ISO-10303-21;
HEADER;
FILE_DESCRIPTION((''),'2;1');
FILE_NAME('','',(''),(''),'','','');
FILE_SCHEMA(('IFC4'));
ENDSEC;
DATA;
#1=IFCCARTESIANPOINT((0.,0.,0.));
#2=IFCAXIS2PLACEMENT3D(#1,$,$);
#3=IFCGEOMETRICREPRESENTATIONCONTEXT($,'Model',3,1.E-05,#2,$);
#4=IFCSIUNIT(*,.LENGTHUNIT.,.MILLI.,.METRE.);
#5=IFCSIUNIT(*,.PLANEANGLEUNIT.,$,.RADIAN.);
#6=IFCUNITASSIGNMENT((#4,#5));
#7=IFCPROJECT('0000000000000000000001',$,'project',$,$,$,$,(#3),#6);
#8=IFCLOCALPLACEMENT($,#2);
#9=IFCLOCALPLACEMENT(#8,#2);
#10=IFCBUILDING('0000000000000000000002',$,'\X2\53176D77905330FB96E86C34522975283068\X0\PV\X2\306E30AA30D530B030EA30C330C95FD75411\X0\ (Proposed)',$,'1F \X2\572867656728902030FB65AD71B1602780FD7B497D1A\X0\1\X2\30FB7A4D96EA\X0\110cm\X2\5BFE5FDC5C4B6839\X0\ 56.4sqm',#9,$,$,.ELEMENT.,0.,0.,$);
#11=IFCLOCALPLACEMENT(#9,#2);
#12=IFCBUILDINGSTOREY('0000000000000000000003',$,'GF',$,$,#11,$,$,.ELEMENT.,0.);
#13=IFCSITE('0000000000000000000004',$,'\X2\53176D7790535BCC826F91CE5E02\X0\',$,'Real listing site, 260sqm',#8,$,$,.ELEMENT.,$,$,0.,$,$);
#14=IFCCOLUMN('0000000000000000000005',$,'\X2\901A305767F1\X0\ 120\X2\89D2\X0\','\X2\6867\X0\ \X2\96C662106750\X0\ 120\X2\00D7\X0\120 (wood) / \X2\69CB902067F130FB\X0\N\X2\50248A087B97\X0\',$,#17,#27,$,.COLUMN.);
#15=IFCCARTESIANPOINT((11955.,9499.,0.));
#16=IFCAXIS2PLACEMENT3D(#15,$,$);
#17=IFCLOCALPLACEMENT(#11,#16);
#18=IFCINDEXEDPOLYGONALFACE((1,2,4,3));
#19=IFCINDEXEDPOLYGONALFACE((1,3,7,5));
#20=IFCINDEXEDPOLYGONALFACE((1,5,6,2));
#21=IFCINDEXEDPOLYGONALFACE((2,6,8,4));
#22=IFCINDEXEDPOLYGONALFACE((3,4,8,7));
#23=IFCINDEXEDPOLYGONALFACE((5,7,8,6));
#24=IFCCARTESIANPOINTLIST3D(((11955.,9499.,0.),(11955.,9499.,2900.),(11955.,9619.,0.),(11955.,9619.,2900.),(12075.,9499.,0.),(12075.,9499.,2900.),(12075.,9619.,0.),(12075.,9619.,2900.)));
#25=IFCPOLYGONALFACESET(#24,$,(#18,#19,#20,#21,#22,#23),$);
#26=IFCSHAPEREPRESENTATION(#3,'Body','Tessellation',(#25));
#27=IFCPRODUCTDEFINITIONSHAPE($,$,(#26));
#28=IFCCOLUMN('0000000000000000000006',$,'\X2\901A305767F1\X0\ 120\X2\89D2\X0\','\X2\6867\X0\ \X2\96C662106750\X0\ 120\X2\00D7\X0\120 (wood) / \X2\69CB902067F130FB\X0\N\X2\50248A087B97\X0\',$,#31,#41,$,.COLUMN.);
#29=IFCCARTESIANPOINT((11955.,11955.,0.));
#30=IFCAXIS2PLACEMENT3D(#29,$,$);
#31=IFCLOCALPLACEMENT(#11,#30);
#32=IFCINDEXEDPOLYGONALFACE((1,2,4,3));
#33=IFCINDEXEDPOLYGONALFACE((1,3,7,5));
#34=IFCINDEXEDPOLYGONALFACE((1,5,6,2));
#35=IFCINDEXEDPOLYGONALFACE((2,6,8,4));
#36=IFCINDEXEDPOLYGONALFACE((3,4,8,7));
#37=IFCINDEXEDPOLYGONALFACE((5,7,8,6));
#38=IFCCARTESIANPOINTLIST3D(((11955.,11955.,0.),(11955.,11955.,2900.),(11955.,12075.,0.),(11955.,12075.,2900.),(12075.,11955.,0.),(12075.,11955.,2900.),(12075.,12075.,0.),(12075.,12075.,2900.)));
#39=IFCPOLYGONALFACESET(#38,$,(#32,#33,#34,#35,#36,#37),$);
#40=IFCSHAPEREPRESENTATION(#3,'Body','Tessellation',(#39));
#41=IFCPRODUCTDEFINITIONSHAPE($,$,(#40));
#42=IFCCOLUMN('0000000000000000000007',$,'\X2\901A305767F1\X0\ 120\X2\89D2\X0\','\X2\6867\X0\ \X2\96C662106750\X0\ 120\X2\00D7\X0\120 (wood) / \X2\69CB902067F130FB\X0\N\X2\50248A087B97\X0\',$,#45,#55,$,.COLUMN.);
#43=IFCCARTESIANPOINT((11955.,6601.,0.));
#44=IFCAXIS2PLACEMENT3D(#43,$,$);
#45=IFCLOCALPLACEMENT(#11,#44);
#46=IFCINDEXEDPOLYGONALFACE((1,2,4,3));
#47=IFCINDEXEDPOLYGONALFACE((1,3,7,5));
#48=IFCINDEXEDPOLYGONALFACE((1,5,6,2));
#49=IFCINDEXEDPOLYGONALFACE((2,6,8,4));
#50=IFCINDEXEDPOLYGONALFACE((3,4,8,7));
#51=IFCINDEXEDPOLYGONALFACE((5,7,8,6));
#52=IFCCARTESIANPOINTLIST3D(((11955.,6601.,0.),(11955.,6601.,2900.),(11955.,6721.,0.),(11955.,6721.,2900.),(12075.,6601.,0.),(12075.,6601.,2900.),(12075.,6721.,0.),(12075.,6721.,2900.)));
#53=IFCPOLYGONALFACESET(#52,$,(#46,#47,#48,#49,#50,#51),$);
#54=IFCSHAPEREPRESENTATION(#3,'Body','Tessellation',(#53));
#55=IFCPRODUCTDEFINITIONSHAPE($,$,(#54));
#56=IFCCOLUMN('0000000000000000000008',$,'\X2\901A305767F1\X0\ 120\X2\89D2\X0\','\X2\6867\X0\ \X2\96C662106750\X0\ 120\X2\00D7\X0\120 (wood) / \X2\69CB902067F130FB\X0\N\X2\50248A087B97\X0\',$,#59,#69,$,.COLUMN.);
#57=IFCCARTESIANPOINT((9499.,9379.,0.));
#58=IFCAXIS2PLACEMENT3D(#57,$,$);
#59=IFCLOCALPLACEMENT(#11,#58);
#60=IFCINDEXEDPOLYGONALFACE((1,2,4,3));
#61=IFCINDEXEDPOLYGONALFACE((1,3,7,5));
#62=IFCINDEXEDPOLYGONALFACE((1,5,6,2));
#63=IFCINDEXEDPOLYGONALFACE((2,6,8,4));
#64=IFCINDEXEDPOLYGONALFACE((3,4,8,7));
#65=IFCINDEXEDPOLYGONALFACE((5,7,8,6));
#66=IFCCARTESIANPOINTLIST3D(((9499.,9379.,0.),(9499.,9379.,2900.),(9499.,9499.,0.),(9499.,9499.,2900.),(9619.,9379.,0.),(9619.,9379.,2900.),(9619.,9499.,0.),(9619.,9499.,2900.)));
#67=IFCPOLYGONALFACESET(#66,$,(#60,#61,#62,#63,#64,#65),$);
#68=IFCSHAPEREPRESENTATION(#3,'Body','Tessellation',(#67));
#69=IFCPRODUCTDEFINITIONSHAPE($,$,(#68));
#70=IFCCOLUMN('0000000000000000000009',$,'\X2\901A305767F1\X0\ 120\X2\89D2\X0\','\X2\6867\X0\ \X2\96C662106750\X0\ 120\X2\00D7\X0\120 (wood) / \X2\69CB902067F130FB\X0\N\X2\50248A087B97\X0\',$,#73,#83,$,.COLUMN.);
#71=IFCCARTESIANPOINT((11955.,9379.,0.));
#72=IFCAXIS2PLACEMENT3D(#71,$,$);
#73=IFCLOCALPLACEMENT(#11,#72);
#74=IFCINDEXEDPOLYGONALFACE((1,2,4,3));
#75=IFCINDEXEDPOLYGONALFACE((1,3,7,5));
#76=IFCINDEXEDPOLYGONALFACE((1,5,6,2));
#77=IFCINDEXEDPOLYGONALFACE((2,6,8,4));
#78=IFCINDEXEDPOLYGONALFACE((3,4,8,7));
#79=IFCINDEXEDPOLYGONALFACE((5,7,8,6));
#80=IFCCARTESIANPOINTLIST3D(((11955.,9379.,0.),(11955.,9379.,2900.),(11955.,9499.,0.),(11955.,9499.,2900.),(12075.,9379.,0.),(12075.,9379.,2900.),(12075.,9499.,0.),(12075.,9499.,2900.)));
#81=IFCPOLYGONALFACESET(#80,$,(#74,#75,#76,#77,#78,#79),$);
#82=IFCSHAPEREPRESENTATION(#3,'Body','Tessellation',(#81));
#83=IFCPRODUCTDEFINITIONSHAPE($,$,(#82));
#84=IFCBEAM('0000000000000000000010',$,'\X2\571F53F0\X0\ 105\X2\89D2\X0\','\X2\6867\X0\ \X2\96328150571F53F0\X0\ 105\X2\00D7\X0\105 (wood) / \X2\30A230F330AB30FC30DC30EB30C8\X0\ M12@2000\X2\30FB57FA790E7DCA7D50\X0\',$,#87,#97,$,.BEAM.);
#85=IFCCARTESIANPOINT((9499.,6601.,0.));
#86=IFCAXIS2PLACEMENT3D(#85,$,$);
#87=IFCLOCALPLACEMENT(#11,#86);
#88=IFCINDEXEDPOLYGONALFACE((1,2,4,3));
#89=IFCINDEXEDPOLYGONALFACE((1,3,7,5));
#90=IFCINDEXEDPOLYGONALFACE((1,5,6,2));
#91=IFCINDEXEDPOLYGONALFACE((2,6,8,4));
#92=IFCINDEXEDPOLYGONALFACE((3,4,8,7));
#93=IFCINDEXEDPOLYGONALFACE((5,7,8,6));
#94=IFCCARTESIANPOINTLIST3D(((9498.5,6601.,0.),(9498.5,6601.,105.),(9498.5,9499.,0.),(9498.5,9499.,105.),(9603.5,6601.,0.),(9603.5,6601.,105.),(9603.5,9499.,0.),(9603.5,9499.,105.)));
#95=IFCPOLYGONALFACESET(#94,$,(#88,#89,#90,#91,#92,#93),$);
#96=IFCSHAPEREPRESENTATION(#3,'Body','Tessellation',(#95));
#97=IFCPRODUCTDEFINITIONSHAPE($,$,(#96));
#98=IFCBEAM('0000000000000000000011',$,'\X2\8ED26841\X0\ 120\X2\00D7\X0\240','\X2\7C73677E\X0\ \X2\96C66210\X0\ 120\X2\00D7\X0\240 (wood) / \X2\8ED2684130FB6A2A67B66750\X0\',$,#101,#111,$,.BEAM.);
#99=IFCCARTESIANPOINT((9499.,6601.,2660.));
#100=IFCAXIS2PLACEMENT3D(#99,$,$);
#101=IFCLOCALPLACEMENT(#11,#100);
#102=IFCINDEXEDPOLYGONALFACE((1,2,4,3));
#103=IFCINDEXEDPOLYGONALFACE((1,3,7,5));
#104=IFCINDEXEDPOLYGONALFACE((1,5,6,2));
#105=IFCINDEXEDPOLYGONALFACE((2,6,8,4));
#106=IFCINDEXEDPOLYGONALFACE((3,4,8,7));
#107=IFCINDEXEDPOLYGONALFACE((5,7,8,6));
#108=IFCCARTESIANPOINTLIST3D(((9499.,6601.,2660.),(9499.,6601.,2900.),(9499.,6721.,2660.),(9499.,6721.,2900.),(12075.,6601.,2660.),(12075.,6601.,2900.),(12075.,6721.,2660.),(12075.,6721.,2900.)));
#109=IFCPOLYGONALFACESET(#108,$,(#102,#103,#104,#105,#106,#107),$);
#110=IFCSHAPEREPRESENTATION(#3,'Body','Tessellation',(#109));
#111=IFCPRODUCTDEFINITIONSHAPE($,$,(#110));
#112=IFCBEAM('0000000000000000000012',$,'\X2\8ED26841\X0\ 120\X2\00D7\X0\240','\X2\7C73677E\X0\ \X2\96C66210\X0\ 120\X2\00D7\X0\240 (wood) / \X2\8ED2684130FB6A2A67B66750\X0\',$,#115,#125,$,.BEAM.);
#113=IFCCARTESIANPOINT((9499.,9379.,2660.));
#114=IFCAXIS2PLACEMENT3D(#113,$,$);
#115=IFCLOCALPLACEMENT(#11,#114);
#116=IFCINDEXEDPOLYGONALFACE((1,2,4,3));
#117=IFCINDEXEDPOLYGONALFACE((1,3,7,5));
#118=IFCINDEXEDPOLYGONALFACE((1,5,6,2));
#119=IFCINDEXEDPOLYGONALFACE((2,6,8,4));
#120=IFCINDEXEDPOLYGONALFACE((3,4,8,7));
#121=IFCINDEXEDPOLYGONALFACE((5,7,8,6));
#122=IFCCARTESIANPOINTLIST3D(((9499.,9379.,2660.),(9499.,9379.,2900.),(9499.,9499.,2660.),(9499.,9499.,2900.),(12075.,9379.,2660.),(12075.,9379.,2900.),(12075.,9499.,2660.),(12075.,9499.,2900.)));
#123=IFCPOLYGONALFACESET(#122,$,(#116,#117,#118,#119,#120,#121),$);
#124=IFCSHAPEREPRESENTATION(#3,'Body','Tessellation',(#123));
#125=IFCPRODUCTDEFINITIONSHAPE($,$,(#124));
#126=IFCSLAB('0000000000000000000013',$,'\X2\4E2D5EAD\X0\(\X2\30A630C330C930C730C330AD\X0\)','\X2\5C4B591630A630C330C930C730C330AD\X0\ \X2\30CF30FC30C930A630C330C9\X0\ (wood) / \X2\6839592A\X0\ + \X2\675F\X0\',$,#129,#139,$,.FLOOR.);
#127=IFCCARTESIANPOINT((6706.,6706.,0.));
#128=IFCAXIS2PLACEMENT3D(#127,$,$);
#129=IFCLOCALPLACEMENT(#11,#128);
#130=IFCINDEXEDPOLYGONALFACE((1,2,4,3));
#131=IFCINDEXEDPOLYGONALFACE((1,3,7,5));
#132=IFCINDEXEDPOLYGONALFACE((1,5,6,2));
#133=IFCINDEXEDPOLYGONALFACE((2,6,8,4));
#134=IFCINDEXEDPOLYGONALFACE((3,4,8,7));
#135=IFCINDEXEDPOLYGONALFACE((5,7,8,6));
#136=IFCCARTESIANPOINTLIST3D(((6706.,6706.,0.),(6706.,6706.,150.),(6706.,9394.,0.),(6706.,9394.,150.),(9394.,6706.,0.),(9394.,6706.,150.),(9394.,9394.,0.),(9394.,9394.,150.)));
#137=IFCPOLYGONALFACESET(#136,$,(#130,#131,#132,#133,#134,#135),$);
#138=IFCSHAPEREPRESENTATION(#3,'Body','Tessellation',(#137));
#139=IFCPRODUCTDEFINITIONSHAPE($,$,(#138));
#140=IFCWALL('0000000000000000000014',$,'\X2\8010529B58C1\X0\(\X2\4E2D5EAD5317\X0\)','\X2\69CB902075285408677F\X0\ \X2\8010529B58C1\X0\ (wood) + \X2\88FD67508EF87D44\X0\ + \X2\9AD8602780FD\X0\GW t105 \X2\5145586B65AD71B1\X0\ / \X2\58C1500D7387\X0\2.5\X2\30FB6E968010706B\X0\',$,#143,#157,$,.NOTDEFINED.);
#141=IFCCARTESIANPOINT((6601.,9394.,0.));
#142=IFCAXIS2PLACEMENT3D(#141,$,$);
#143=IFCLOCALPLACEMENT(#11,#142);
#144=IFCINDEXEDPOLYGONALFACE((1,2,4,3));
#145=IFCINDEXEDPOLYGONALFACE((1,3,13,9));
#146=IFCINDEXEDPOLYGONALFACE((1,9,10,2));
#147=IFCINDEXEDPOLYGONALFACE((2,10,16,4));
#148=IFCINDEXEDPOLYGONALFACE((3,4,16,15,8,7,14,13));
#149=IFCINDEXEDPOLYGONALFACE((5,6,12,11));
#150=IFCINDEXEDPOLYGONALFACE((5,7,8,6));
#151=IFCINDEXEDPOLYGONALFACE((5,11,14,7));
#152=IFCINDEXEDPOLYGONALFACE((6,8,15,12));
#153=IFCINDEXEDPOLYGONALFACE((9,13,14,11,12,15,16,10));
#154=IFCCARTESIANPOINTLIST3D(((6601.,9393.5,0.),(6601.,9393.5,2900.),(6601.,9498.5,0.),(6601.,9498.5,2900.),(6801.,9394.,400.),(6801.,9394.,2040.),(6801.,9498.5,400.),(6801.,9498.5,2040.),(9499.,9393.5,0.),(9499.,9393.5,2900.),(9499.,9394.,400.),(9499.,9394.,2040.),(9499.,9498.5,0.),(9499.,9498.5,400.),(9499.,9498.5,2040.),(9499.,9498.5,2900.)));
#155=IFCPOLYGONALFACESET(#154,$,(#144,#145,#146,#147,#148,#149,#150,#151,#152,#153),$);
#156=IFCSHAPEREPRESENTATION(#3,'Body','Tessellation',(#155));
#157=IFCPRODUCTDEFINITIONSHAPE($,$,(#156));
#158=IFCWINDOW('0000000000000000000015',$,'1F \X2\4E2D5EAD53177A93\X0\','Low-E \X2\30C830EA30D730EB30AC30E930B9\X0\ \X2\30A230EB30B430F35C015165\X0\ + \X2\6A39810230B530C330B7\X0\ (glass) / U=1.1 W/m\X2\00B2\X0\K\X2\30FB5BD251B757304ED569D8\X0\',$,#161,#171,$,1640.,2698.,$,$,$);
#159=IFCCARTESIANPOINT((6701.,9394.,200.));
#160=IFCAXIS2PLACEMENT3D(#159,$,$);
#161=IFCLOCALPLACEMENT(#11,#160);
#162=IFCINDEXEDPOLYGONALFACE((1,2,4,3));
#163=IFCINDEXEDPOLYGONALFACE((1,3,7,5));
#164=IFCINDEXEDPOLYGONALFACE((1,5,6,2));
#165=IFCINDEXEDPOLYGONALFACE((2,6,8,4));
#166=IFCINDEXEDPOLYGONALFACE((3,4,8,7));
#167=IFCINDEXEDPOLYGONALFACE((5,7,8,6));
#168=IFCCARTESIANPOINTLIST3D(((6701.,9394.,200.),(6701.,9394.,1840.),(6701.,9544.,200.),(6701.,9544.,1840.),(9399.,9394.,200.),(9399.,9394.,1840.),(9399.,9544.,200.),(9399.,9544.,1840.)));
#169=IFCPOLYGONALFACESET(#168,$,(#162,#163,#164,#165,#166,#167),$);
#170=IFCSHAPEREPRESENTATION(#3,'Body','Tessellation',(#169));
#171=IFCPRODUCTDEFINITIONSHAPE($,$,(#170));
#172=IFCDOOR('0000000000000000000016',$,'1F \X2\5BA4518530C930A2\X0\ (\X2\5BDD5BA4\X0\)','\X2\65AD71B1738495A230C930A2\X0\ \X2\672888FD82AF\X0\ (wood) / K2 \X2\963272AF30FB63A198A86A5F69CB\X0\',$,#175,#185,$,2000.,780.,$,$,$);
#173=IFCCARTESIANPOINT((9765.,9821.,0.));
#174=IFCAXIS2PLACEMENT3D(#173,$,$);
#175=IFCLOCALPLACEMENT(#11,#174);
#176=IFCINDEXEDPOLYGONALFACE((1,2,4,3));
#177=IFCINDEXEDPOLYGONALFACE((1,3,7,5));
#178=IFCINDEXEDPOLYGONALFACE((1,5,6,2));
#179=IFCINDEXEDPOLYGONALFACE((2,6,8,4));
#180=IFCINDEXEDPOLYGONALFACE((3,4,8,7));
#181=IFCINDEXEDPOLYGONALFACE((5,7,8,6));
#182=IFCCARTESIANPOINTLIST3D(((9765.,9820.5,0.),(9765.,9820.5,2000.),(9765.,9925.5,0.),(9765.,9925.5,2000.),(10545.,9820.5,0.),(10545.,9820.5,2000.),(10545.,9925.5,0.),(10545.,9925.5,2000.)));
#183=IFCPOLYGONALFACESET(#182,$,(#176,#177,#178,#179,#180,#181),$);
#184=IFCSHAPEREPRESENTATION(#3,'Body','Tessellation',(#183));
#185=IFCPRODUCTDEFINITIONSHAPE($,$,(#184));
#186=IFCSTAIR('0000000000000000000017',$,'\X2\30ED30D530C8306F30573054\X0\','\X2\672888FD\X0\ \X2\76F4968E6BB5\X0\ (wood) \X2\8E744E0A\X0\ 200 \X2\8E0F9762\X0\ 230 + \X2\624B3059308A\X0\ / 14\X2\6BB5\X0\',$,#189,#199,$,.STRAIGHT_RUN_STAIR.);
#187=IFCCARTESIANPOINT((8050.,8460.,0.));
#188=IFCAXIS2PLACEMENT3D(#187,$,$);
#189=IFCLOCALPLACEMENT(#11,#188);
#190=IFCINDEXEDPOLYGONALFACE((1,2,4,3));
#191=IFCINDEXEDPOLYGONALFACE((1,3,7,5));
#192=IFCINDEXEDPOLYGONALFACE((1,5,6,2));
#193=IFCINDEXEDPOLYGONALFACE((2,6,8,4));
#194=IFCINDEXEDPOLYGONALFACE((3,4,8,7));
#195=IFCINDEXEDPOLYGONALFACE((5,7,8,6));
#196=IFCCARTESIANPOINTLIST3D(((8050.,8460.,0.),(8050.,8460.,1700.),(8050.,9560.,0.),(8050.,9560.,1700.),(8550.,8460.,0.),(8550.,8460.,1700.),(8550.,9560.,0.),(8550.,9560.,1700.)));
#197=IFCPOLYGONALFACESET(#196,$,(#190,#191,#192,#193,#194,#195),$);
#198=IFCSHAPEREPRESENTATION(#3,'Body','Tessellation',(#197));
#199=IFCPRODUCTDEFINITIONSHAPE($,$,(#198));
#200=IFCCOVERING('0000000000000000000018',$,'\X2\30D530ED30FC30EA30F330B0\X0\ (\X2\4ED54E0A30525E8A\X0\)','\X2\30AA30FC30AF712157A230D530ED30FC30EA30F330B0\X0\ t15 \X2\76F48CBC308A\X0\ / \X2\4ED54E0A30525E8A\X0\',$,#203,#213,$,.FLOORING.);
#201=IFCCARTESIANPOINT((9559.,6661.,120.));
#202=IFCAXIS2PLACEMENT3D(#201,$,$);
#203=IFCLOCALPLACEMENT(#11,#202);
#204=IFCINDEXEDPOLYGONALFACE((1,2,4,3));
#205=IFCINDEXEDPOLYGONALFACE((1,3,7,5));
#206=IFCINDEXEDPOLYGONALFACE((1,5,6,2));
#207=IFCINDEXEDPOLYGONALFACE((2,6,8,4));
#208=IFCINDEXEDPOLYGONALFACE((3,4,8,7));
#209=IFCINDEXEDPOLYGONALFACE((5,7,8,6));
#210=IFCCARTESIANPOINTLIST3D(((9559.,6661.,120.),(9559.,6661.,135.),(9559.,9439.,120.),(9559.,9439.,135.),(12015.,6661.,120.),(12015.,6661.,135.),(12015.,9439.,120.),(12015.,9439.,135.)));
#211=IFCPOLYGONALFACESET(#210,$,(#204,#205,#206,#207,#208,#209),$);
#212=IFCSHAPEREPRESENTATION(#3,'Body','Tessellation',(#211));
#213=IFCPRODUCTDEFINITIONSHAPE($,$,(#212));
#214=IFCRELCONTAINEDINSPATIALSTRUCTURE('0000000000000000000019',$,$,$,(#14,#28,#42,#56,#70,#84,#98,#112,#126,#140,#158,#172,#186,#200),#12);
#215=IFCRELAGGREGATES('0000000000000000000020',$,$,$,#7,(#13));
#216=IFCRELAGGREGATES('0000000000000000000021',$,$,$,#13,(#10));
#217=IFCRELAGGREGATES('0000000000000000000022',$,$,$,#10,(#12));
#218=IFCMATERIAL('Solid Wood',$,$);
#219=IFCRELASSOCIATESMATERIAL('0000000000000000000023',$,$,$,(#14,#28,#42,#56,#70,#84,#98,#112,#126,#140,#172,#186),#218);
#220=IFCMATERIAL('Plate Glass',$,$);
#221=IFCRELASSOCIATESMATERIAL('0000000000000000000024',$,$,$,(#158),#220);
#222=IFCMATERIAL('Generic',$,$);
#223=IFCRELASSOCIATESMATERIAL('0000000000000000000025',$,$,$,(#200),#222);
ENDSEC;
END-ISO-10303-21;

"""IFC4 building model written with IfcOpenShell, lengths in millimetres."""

from ifc_helpers import new_model, si_unit, frame, frame_2d, origin, place, context, project, spatial, rectangle, extrude, material, element, fill, save


model = new_model("IFC4")

# Units and contexts
model_context = context("Model", 3, precision=1e-05, world=origin())
ifc_project = project(units=[si_unit("LENGTHUNIT", "METRE", prefix="MILLI"), si_unit("PLANEANGLEUNIT", "RADIAN")], contexts=[model_context])

# Site, building, storey
site_placement = place(None, origin())
site = spatial("IfcSite", under=ifc_project, at=site_placement, Name="北海道富良野市", ObjectType="Real listing site, 260sqm", CompositionType="ELEMENT", RefElevation=0.0)
building_placement = place(site_placement, origin())
building = spatial("IfcBuilding", under=site, at=building_placement, Name="北海道・雨水利用とPVのオフグリッド志向 (Proposed)", ObjectType="1F 在来木造・断熱性能等級1・積雪110cm対応屋根 56.4sqm", CompositionType="ELEMENT", ElevationOfRefHeight=0.0, ElevationOfTerrain=0.0)
storey_placement = place(building_placement, origin())
storey = spatial("IfcBuildingStorey", under=building, at=storey_placement, Name="GF", CompositionType="ELEMENT", Elevation=0.0)

# Columns
ifc_material_1 = material(Name="Solid Wood")
column_1_placement = place(storey_placement, frame((11955.0, 9499.0, 0.0)))
element("IfcColumn", 1, at=column_1_placement, inside=storey, material=ifc_material_1, Name="通し柱 120角", Description="桧 集成材 120×120 (wood) / 構造柱・N値計算", PredefinedType="COLUMN", context=model_context, shape_type="SweptSolid", body=[
    extrude(rectangle(XDim=120.0, YDim=120.0, at=frame_2d((60.0, 60.0))), frame((11955.0, 9499.0, 0.0)), (0.0, 0.0, 1.0), 2900.0),
])
column_2_placement = place(storey_placement, frame((11955.0, 11955.0, 0.0)))
element("IfcColumn", 2, at=column_2_placement, inside=storey, material=ifc_material_1, Name="通し柱 120角", Description="桧 集成材 120×120 (wood) / 構造柱・N値計算", PredefinedType="COLUMN", context=model_context, shape_type="SweptSolid", body=[
    extrude(rectangle(XDim=120.0, YDim=120.0, at=frame_2d((60.0, 60.0))), frame((11955.0, 11955.0, 0.0)), (0.0, 0.0, 1.0), 2900.0),
])
column_3_placement = place(storey_placement, frame((11955.0, 6601.0, 0.0)))
element("IfcColumn", 3, at=column_3_placement, inside=storey, material=ifc_material_1, Name="通し柱 120角", Description="桧 集成材 120×120 (wood) / 構造柱・N値計算", PredefinedType="COLUMN", context=model_context, shape_type="SweptSolid", body=[
    extrude(rectangle(XDim=120.0, YDim=120.0, at=frame_2d((60.0, 60.0))), frame((11955.0, 6601.0, 0.0)), (0.0, 0.0, 1.0), 2900.0),
])
column_4_placement = place(storey_placement, frame((9499.0, 9379.0, 0.0)))
element("IfcColumn", 4, at=column_4_placement, inside=storey, material=ifc_material_1, Name="通し柱 120角", Description="桧 集成材 120×120 (wood) / 構造柱・N値計算", PredefinedType="COLUMN", context=model_context, shape_type="SweptSolid", body=[
    extrude(rectangle(XDim=120.0, YDim=120.0, at=frame_2d((60.0, 60.0))), frame((9499.0, 9379.0, 0.0)), (0.0, 0.0, 1.0), 2900.0),
])
column_5_placement = place(storey_placement, frame((11955.0, 9379.0, 0.0)))
element("IfcColumn", 5, at=column_5_placement, inside=storey, material=ifc_material_1, Name="通し柱 120角", Description="桧 集成材 120×120 (wood) / 構造柱・N値計算", PredefinedType="COLUMN", context=model_context, shape_type="SweptSolid", body=[
    extrude(rectangle(XDim=120.0, YDim=120.0, at=frame_2d((60.0, 60.0))), frame((11955.0, 9379.0, 0.0)), (0.0, 0.0, 1.0), 2900.0),
])

# Beams
beam_1_placement = place(storey_placement, frame((9499.0, 6601.0, 0.0)))
element("IfcBeam", 6, at=beam_1_placement, inside=storey, material=ifc_material_1, Name="土台 105角", Description="桧 防腐土台 105×105 (wood) / アンカーボルト M12@2000・基礎緊結", PredefinedType="BEAM", context=model_context, shape_type="SweptSolid", body=[
    extrude(rectangle(XDim=105.0, YDim=2898.0, at=frame_2d((52.0, 1449.0))), frame((9499.0, 6601.0, 0.0)), (0.0, 0.0, 1.0), 105.0),
])
beam_2_placement = place(storey_placement, frame((9499.0, 6601.0, 2660.0)))
element("IfcBeam", 7, at=beam_2_placement, inside=storey, material=ifc_material_1, Name="軒桁 120×240", Description="米松 集成 120×240 (wood) / 軒桁・横架材", PredefinedType="BEAM", context=model_context, shape_type="SweptSolid", body=[
    extrude(rectangle(XDim=2576.0, YDim=120.0, at=frame_2d((1288.0, 60.0))), frame((9499.0, 6601.0, 2660.0)), (0.0, 0.0, 1.0), 240.0),
])
beam_3_placement = place(storey_placement, frame((9499.0, 9379.0, 2660.0)))
element("IfcBeam", 8, at=beam_3_placement, inside=storey, material=ifc_material_1, Name="軒桁 120×240", Description="米松 集成 120×240 (wood) / 軒桁・横架材", PredefinedType="BEAM", context=model_context, shape_type="SweptSolid", body=[
    extrude(rectangle(XDim=2576.0, YDim=120.0, at=frame_2d((1288.0, 60.0))), frame((9499.0, 9379.0, 2660.0)), (0.0, 0.0, 1.0), 240.0),
])

# Slab
slab_placement = place(storey_placement, frame((6706.0, 6706.0, 0.0)))
element("IfcSlab", 9, at=slab_placement, inside=storey, material=ifc_material_1, Name="中庭(ウッドデッキ)", Description="屋外ウッドデッキ ハードウッド (wood) / 根太 + 束", PredefinedType="FLOOR", context=model_context, shape_type="SweptSolid", body=[
    extrude(rectangle(XDim=2688.0, YDim=2688.0, at=frame_2d((1344.0, 1344.0))), frame((6706.0, 6706.0, 0.0)), (0.0, 0.0, 1.0), 150.0),
])

# Wall, opening, window
wall_1_placement = place(storey_placement, frame((6601.0, 9394.0, 0.0)))
wall_1 = element("IfcWall", 10, at=wall_1_placement, inside=storey, material=ifc_material_1, Name="耐力壁(中庭北)", Description="構造用合板 耐力壁 (wood) + 製材軸組 + 高性能GW t105 充填断熱 / 壁倍率2.5・準耐火", PredefinedType="NOTDEFINED", context=model_context, shape_type="SweptSolid", body=[
    extrude(rectangle(XDim=2898.0, YDim=105.0, at=frame_2d((1449.0, 52.0))), frame((6601.0, 9394.0, 0.0)), (0.0, 0.0, 1.0), 2900.0),
])
opening_placement = place(storey_placement, frame((6701.0, 9394.0, 200.0)))
opening = element("IfcOpeningElement", 11, at=opening_placement, cuts=wall_1, PredefinedType="NOTDEFINED", context=model_context, shape_type="SweptSolid", body=[
    extrude(rectangle(XDim=2698.0, YDim=150.0, at=frame_2d((1349.0, 75.0))), frame((6701.0, 9394.0, 200.0)), (0.0, 0.0, 1.0), 1640.0),
])
ifc_material_2 = material(Name="Plate Glass")
window_placement = place(storey_placement, frame((6701.0, 9394.0, 200.0)))
window = element("IfcWindow", 12, at=window_placement, inside=storey, material=ifc_material_2, Name="1F 中庭北窓", Description="Low-E トリプルガラス アルゴン封入 + 樹脂サッシ (glass) / U=1.1 W/m²K・寒冷地仕様", OverallHeight=1640.0, OverallWidth=2698.0, context=model_context, shape_type="SweptSolid", body=[
    extrude(rectangle(XDim=2698.0, YDim=150.0, at=frame_2d((1349.0, 75.0))), frame((6701.0, 9394.0, 200.0)), (0.0, 0.0, 1.0), 1640.0),
])
fill(opening, window)

# Door
door_placement = place(storey_placement, frame((9765.0, 9821.0, 0.0)))
element("IfcDoor", 13, at=door_placement, inside=storey, material=ifc_material_1, Name="1F 室内ドア (寝室)", Description="断熱玄関ドア 木製芯 (wood) / K2 防犯・採風機構", OverallHeight=2000.0, OverallWidth=780.0, context=model_context, shape_type="SweptSolid", body=[
    extrude(rectangle(XDim=780.0, YDim=105.0, at=frame_2d((390.0, 52.0))), frame((9765.0, 9821.0, 0.0)), (0.0, 0.0, 1.0), 2000.0),
])

# Stair
stair_placement = place(storey_placement, frame((8050.0, 8460.0, 0.0)))
element("IfcStair", 14, at=stair_placement, inside=storey, material=ifc_material_1, Name="ロフトはしご", Description="木製 直階段 (wood) 蹴上 200 踏面 230 + 手すり / 14段", PredefinedType="STRAIGHT_RUN_STAIR", context=model_context, shape_type="SweptSolid", body=[
    extrude(rectangle(XDim=500.0, YDim=1100.0, at=frame_2d((250.0, 550.0))), frame((8050.0, 8460.0, 0.0)), (0.0, 0.0, 1.0), 1700.0),
])

# Covering
ifc_material_3 = material(Name="Generic")
covering_placement = place(storey_placement, frame((9559.0, 6661.0, 120.0)))
element("IfcCovering", 15, at=covering_placement, inside=storey, material=ifc_material_3, Name="フローリング (仕上げ床)", Description="オーク無垢フローリング t15 直貼り / 仕上げ床", PredefinedType="FLOORING", context=model_context, shape_type="SweptSolid", body=[
    extrude(rectangle(XDim=2456.0, YDim=2778.0, at=frame_2d((1228.0, 1389.0))), frame((9559.0, 6661.0, 120.0)), (0.0, 0.0, 1.0), 15.0),
])

save(model, "model.ifc")
